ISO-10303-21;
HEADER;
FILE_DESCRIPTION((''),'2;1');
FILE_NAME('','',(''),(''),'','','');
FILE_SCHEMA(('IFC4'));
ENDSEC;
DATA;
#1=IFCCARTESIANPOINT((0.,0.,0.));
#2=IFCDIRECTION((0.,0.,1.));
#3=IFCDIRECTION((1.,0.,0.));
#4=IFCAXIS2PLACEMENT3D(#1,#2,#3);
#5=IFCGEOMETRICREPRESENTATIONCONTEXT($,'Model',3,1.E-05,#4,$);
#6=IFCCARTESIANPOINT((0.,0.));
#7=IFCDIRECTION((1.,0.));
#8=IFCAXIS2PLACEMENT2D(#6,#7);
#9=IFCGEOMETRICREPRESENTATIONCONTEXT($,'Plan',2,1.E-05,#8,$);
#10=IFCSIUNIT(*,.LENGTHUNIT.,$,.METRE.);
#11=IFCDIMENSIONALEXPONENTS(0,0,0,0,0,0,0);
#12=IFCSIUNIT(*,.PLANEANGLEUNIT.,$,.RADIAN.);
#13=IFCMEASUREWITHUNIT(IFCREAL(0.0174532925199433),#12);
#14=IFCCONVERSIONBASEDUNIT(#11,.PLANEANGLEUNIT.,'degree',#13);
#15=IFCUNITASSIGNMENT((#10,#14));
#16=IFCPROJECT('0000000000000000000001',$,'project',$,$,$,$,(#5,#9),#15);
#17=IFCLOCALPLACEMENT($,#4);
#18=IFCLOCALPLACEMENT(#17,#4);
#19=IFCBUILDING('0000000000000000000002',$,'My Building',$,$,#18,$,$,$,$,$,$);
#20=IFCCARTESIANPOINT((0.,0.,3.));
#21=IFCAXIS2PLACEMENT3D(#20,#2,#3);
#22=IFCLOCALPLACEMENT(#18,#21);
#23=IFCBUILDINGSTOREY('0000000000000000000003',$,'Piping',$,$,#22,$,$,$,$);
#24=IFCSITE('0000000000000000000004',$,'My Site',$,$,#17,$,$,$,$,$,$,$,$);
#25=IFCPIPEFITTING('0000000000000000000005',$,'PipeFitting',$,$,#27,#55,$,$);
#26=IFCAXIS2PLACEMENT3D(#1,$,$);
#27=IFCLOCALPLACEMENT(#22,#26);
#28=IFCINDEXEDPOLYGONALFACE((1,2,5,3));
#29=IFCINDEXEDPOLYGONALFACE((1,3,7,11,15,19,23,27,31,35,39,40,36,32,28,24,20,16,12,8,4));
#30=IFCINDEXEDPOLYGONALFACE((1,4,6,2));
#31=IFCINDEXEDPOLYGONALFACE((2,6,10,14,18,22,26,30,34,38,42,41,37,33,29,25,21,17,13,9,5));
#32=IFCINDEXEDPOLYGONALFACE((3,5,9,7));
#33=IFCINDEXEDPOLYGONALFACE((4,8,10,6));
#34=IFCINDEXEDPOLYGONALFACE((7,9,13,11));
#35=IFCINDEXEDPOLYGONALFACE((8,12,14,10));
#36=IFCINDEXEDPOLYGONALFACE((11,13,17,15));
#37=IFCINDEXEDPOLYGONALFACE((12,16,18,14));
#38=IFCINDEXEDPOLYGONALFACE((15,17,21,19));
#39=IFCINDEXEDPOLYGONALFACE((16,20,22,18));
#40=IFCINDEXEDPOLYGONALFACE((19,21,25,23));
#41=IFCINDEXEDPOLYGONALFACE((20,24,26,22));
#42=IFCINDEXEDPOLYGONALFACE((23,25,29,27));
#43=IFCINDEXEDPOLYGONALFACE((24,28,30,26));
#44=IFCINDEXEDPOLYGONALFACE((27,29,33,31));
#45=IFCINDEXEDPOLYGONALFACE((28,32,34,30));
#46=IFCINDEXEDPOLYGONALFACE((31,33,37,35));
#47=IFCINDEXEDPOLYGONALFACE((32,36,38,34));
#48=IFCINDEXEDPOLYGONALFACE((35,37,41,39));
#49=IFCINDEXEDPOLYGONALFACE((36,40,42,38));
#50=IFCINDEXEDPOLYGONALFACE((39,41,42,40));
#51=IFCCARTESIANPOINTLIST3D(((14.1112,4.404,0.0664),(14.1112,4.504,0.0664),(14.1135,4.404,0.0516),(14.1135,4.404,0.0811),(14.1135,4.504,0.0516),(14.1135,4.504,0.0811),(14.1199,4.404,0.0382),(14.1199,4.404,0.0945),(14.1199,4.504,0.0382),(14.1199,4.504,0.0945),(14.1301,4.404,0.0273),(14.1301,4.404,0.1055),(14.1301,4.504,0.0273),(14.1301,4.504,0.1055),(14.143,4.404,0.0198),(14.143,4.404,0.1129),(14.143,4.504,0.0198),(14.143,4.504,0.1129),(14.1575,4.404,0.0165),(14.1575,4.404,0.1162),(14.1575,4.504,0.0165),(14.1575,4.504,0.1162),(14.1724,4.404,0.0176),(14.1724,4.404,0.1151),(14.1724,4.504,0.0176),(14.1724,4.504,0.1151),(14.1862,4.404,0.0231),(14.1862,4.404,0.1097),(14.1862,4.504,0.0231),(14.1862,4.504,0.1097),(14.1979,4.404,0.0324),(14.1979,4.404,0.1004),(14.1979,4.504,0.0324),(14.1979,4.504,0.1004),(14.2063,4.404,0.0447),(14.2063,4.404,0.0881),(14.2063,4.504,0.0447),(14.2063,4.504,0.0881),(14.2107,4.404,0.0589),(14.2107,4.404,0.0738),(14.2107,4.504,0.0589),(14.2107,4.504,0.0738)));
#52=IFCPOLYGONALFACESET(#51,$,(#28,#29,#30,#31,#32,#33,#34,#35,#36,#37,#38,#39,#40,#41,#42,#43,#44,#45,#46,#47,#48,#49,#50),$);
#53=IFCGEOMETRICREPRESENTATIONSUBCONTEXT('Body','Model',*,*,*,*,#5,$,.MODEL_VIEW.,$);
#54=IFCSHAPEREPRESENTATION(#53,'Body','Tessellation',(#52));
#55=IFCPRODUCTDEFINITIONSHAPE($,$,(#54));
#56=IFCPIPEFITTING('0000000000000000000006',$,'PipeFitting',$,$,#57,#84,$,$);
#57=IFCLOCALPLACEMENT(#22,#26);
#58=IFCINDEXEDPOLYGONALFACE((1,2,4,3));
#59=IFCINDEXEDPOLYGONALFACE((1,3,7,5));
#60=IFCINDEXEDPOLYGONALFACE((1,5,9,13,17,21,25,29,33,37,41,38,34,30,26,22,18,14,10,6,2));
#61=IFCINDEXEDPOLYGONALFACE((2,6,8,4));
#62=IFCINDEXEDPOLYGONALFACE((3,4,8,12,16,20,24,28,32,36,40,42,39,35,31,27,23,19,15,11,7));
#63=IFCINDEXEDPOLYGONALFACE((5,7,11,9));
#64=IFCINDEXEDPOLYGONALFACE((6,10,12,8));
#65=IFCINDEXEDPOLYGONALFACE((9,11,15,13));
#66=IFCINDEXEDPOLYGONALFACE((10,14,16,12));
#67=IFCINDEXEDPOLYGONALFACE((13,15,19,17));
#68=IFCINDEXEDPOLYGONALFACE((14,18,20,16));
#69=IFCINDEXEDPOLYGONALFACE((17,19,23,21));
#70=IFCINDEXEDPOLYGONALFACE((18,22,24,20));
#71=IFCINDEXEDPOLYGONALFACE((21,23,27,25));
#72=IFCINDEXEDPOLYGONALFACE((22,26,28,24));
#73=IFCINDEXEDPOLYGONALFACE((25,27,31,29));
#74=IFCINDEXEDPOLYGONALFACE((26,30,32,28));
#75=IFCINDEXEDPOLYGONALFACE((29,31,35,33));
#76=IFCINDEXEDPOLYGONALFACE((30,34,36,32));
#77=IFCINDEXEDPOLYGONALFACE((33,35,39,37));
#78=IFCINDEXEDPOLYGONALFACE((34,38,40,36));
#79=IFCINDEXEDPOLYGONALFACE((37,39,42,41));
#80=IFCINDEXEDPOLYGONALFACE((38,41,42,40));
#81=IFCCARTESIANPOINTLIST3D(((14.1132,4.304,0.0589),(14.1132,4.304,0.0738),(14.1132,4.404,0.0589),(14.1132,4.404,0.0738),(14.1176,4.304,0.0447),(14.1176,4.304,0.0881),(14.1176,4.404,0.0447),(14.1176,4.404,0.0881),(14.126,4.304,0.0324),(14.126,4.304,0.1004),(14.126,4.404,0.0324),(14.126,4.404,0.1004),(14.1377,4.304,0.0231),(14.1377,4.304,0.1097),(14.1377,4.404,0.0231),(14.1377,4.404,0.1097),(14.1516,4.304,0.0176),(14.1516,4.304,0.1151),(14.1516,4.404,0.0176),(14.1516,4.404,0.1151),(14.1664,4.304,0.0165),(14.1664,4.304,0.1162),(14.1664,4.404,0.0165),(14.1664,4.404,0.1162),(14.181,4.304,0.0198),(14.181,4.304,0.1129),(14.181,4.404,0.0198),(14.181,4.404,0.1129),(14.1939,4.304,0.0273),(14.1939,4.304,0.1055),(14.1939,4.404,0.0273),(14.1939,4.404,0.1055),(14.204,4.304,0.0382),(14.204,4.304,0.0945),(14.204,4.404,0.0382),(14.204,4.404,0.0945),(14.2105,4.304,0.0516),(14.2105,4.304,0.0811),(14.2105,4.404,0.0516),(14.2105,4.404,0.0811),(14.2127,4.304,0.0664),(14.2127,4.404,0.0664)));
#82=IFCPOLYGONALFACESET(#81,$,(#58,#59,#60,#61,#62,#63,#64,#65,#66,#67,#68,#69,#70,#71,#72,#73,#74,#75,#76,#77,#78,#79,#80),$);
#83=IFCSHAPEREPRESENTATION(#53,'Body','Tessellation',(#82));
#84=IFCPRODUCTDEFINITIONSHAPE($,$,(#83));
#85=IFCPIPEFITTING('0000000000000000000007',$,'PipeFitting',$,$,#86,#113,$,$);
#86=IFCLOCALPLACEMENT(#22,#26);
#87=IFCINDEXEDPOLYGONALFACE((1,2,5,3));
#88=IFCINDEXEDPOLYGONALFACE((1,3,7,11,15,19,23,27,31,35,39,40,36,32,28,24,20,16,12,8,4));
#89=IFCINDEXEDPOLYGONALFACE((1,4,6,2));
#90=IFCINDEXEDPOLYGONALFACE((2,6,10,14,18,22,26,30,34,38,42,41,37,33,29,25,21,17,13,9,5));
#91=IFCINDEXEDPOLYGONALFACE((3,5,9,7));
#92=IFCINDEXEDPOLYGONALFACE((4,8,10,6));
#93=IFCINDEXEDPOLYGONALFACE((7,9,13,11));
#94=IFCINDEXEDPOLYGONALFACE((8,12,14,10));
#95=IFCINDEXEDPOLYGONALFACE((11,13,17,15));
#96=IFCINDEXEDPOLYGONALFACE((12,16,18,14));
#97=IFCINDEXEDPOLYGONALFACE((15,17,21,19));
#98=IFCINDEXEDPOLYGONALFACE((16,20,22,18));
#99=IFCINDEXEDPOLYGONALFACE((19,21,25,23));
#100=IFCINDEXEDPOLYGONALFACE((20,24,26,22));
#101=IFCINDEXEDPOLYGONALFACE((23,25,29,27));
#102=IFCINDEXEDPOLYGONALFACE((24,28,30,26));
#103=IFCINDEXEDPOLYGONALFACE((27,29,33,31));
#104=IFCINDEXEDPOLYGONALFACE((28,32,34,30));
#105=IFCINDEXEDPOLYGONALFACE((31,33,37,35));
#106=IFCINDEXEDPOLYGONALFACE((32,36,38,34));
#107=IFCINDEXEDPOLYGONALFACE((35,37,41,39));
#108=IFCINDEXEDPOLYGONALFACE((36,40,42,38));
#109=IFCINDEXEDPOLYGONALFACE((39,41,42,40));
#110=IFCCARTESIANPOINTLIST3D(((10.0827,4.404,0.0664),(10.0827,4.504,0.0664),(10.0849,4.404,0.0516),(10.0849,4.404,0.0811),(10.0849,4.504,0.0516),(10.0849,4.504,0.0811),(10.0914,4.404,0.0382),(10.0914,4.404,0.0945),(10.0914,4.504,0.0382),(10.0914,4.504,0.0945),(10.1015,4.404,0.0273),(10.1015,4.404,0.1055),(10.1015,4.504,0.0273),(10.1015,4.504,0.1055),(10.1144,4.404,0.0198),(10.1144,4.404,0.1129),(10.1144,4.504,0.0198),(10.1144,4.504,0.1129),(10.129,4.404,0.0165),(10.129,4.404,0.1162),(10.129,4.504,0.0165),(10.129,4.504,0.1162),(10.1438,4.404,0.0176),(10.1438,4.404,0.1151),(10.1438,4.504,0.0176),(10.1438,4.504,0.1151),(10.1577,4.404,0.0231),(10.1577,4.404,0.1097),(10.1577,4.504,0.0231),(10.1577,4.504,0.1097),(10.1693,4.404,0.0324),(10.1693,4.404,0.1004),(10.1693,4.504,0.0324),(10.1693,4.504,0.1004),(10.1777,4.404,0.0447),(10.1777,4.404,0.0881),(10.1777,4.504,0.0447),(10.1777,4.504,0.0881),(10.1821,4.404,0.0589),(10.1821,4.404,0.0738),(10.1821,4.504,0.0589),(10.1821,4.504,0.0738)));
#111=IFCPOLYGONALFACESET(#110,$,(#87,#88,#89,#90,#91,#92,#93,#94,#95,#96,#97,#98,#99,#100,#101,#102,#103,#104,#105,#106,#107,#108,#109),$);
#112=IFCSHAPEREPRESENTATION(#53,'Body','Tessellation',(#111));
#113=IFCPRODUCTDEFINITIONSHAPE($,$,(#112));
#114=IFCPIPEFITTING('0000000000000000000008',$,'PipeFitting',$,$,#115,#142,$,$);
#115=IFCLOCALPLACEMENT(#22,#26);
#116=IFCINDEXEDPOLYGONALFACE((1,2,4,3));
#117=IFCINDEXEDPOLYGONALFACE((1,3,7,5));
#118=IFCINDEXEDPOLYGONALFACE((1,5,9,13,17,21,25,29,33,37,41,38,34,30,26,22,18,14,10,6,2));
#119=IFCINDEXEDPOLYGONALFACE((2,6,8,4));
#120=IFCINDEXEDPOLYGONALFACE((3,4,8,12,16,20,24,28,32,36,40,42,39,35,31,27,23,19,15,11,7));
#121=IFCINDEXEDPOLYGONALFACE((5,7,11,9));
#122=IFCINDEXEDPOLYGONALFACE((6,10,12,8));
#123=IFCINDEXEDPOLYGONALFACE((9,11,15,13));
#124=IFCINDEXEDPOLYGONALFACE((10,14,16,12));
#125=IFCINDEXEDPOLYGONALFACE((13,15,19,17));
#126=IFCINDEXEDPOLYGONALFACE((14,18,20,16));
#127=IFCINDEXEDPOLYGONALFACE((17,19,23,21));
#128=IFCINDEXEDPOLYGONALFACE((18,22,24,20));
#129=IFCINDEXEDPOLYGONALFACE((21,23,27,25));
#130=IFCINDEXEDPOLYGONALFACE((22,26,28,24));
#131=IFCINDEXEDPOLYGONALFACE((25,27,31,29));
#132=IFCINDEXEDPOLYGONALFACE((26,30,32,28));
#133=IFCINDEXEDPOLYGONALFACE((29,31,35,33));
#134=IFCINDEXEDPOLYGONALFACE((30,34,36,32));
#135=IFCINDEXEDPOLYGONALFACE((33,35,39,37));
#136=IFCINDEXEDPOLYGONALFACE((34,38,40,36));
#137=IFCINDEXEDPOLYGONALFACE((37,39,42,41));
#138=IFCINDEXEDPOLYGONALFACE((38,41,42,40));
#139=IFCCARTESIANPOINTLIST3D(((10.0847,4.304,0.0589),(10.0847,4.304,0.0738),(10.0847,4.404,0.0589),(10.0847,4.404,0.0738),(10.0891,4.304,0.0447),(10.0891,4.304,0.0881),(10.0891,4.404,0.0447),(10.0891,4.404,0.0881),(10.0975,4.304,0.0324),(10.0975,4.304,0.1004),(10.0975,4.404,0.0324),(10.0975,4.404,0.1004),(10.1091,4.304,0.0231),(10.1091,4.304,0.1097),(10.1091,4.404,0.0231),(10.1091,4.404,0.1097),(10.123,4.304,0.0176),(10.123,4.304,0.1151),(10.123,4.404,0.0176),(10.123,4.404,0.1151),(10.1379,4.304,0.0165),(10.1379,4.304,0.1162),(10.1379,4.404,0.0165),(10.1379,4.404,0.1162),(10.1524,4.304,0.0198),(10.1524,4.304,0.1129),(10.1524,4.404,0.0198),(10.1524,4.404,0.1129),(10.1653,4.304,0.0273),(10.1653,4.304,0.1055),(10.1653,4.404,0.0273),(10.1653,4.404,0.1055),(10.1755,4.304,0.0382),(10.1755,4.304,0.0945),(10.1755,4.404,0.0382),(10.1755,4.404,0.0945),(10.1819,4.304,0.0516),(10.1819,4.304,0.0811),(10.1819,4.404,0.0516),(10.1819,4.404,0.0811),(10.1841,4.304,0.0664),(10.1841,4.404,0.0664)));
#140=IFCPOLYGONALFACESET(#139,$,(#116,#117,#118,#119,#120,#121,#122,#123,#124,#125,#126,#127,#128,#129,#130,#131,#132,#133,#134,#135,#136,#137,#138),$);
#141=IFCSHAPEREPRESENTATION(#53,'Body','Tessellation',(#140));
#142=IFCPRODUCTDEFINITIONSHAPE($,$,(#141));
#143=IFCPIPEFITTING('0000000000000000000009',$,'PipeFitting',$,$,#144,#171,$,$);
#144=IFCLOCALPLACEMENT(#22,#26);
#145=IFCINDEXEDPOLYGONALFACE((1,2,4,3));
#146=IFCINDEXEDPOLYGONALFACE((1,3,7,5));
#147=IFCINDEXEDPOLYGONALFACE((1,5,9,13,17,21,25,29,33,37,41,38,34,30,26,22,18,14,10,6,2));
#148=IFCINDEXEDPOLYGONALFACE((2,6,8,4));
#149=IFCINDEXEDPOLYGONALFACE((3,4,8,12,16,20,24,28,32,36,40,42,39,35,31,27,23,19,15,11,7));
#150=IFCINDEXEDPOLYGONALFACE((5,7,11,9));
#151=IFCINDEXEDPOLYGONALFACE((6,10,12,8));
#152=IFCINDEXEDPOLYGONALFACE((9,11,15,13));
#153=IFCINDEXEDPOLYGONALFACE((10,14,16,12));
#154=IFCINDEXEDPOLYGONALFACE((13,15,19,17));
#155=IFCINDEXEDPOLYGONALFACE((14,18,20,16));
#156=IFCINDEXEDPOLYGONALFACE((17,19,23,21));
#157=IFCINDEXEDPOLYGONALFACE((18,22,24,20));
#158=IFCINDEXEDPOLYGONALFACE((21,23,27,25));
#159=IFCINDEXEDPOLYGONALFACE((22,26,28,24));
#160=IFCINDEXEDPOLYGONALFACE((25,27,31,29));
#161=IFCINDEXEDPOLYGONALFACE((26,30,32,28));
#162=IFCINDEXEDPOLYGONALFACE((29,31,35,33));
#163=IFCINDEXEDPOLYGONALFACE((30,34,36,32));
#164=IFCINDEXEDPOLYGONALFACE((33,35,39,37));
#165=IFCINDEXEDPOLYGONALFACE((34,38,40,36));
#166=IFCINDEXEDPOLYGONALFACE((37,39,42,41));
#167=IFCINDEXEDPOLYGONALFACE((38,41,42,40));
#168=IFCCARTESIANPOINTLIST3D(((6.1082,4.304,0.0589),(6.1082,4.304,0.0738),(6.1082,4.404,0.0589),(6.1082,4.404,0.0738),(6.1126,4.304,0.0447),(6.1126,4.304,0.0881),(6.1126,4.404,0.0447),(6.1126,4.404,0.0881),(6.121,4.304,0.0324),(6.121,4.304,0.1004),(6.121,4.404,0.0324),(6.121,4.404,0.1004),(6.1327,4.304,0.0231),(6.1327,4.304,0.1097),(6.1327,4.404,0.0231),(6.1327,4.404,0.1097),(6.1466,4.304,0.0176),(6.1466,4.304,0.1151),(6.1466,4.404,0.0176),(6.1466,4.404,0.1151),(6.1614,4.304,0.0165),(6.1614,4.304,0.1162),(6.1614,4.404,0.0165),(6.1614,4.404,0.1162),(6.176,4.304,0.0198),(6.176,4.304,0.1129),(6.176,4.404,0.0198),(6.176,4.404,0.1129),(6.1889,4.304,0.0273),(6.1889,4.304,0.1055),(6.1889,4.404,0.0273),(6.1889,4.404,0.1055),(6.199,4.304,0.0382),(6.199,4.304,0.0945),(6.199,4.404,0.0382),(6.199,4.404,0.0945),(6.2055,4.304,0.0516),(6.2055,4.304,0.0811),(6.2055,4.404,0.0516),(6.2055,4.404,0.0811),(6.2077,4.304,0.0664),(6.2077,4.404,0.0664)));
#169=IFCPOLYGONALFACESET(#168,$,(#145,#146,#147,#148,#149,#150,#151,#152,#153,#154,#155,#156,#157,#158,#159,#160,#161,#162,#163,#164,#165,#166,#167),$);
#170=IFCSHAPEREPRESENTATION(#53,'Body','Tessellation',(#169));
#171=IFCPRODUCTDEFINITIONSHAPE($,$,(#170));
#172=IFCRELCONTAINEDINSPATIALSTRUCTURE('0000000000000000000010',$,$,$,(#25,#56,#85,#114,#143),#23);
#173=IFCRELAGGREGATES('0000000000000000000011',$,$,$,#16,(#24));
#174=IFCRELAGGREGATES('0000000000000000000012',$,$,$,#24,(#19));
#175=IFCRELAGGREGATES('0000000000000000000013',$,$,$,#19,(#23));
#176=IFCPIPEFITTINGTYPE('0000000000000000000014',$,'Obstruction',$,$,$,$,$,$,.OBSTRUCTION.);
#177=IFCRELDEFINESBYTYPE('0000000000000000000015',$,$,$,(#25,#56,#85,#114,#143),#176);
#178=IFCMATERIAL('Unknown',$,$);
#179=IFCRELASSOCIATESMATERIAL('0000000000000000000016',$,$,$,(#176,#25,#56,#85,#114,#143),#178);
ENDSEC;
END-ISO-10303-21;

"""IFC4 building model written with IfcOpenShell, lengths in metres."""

from ifc_helpers import new_model, entity, si_unit, converted_unit, frame, origin_with_axes, origin_2d_with_axis, place, context, subcontext, project, spatial, circle, extrude, material, material_profile, profile_set, profile_usage, type_object, element, save


model = new_model("IFC4")

# Units and contexts
model_context = context("Model", 3, precision=1e-05, world=origin_with_axes())
plan_context = context("Plan", 2, precision=1e-05, world=origin_2d_with_axis())
body_context = subcontext(model_context, "Body", "Model", "MODEL_VIEW")
ifc_project = project(units=[si_unit("LENGTHUNIT", "METRE"), converted_unit("PLANEANGLEUNIT", "degree", entity("IfcReal", 0.0174532925199433), si_unit("PLANEANGLEUNIT", "RADIAN"), dimensions=[0, 0, 0, 0, 0, 0, 0])], contexts=[model_context, plan_context])

# Site, building, storey
site_placement = place(None, origin_with_axes())
site = spatial("IfcSite", under=ifc_project, at=site_placement, Name="My Site")
building_placement = place(site_placement, origin_with_axes())
building = spatial("IfcBuilding", under=site, at=building_placement, Name="My Building")
storey_placement = place(building_placement, frame((0.0, 0.0, 3.0), z_axis=(0.0, 0.0, 1.0), x_axis=(1.0, 0.0, 0.0)))
storey = spatial("IfcBuildingStorey", under=building, at=storey_placement, Name="Piping")

# Shared definitions
ifc_material = material(Name="Unknown")

# Pipe fittings
ifc_material_profile_1 = material_profile(ifc_material, circle(Radius=0.05))
ifc_profile_set_1 = profile_set([ifc_material_profile_1])
ifc_profile_usage_1 = profile_usage(ifc_profile_set_1, cardinal=5)
pipe_fitting_type_1 = type_object("IfcPipeFittingType", Name="Obstruction", PredefinedType="OBSTRUCTION", material=ifc_profile_set_1)
pipe_fitting_1_placement = place(storey_placement, frame((14.1612, 4.404, 0.0664), z_axis=(0.0, 1.0, 0.0), x_axis=(-1.0, 0.0, 0.0)))
element("IfcPipeFitting", 1, at=pipe_fitting_1_placement, inside=storey, type_object=pipe_fitting_type_1, material=ifc_profile_usage_1, Name="PipeFitting", context=body_context, shape_type="SweptSolid", body=[
    extrude(circle(Radius=0.05), origin_with_axes(), (0.0, 0.0, 1.0), 0.1),
])
ifc_profile_usage_2 = profile_usage(ifc_profile_set_1, cardinal=5)
pipe_fitting_2_placement = place(storey_placement, frame((14.1627, 4.404, 0.0664), z_axis=(0.0, -1.0, 0.000002), x_axis=(1.0, 0.0, 0.0)))
element("IfcPipeFitting", 2, at=pipe_fitting_2_placement, inside=storey, type_object=pipe_fitting_type_1, material=ifc_profile_usage_2, Name="PipeFitting", context=body_context, shape_type="SweptSolid", body=[
    extrude(circle(Radius=0.05), origin_with_axes(), (0.0, 0.0, 1.0), 0.1),
])
ifc_profile_usage_3 = profile_usage(ifc_profile_set_1, cardinal=5)
pipe_fitting_3_placement = place(storey_placement, frame((10.1327, 4.404, 0.0664), z_axis=(0.0, 1.0, 0.0), x_axis=(-1.0, 0.0, 0.0)))
element("IfcPipeFitting", 3, at=pipe_fitting_3_placement, inside=storey, type_object=pipe_fitting_type_1, material=ifc_profile_usage_3, Name="PipeFitting", context=body_context, shape_type="SweptSolid", body=[
    extrude(circle(Radius=0.05), origin_with_axes(), (0.0, 0.0, 1.0), 0.1),
])
ifc_profile_usage_4 = profile_usage(ifc_profile_set_1, cardinal=5)
pipe_fitting_4_placement = place(storey_placement, frame((10.1341, 4.404, 0.0664), z_axis=(0.0, -1.0, 0.000002), x_axis=(1.0, 0.0, 0.0)))
element("IfcPipeFitting", 4, at=pipe_fitting_4_placement, inside=storey, type_object=pipe_fitting_type_1, material=ifc_profile_usage_4, Name="PipeFitting", context=body_context, shape_type="SweptSolid", body=[
    extrude(circle(Radius=0.05), origin_with_axes(), (0.0, 0.0, 1.0), 0.1),
])
ifc_profile_usage_5 = profile_usage(ifc_profile_set_1, cardinal=5)
pipe_fitting_5_placement = place(storey_placement, frame((6.1577, 4.404, 0.0664), z_axis=(0.0, -1.0, 0.000002), x_axis=(1.0, 0.0, 0.0)))
element("IfcPipeFitting", 5, at=pipe_fitting_5_placement, inside=storey, type_object=pipe_fitting_type_1, material=ifc_profile_usage_5, Name="PipeFitting", context=body_context, shape_type="SweptSolid", body=[
    extrude(circle(Radius=0.05), origin_with_axes(), (0.0, 0.0, 1.0), 0.1),
])

save(model, "model.ifc")
